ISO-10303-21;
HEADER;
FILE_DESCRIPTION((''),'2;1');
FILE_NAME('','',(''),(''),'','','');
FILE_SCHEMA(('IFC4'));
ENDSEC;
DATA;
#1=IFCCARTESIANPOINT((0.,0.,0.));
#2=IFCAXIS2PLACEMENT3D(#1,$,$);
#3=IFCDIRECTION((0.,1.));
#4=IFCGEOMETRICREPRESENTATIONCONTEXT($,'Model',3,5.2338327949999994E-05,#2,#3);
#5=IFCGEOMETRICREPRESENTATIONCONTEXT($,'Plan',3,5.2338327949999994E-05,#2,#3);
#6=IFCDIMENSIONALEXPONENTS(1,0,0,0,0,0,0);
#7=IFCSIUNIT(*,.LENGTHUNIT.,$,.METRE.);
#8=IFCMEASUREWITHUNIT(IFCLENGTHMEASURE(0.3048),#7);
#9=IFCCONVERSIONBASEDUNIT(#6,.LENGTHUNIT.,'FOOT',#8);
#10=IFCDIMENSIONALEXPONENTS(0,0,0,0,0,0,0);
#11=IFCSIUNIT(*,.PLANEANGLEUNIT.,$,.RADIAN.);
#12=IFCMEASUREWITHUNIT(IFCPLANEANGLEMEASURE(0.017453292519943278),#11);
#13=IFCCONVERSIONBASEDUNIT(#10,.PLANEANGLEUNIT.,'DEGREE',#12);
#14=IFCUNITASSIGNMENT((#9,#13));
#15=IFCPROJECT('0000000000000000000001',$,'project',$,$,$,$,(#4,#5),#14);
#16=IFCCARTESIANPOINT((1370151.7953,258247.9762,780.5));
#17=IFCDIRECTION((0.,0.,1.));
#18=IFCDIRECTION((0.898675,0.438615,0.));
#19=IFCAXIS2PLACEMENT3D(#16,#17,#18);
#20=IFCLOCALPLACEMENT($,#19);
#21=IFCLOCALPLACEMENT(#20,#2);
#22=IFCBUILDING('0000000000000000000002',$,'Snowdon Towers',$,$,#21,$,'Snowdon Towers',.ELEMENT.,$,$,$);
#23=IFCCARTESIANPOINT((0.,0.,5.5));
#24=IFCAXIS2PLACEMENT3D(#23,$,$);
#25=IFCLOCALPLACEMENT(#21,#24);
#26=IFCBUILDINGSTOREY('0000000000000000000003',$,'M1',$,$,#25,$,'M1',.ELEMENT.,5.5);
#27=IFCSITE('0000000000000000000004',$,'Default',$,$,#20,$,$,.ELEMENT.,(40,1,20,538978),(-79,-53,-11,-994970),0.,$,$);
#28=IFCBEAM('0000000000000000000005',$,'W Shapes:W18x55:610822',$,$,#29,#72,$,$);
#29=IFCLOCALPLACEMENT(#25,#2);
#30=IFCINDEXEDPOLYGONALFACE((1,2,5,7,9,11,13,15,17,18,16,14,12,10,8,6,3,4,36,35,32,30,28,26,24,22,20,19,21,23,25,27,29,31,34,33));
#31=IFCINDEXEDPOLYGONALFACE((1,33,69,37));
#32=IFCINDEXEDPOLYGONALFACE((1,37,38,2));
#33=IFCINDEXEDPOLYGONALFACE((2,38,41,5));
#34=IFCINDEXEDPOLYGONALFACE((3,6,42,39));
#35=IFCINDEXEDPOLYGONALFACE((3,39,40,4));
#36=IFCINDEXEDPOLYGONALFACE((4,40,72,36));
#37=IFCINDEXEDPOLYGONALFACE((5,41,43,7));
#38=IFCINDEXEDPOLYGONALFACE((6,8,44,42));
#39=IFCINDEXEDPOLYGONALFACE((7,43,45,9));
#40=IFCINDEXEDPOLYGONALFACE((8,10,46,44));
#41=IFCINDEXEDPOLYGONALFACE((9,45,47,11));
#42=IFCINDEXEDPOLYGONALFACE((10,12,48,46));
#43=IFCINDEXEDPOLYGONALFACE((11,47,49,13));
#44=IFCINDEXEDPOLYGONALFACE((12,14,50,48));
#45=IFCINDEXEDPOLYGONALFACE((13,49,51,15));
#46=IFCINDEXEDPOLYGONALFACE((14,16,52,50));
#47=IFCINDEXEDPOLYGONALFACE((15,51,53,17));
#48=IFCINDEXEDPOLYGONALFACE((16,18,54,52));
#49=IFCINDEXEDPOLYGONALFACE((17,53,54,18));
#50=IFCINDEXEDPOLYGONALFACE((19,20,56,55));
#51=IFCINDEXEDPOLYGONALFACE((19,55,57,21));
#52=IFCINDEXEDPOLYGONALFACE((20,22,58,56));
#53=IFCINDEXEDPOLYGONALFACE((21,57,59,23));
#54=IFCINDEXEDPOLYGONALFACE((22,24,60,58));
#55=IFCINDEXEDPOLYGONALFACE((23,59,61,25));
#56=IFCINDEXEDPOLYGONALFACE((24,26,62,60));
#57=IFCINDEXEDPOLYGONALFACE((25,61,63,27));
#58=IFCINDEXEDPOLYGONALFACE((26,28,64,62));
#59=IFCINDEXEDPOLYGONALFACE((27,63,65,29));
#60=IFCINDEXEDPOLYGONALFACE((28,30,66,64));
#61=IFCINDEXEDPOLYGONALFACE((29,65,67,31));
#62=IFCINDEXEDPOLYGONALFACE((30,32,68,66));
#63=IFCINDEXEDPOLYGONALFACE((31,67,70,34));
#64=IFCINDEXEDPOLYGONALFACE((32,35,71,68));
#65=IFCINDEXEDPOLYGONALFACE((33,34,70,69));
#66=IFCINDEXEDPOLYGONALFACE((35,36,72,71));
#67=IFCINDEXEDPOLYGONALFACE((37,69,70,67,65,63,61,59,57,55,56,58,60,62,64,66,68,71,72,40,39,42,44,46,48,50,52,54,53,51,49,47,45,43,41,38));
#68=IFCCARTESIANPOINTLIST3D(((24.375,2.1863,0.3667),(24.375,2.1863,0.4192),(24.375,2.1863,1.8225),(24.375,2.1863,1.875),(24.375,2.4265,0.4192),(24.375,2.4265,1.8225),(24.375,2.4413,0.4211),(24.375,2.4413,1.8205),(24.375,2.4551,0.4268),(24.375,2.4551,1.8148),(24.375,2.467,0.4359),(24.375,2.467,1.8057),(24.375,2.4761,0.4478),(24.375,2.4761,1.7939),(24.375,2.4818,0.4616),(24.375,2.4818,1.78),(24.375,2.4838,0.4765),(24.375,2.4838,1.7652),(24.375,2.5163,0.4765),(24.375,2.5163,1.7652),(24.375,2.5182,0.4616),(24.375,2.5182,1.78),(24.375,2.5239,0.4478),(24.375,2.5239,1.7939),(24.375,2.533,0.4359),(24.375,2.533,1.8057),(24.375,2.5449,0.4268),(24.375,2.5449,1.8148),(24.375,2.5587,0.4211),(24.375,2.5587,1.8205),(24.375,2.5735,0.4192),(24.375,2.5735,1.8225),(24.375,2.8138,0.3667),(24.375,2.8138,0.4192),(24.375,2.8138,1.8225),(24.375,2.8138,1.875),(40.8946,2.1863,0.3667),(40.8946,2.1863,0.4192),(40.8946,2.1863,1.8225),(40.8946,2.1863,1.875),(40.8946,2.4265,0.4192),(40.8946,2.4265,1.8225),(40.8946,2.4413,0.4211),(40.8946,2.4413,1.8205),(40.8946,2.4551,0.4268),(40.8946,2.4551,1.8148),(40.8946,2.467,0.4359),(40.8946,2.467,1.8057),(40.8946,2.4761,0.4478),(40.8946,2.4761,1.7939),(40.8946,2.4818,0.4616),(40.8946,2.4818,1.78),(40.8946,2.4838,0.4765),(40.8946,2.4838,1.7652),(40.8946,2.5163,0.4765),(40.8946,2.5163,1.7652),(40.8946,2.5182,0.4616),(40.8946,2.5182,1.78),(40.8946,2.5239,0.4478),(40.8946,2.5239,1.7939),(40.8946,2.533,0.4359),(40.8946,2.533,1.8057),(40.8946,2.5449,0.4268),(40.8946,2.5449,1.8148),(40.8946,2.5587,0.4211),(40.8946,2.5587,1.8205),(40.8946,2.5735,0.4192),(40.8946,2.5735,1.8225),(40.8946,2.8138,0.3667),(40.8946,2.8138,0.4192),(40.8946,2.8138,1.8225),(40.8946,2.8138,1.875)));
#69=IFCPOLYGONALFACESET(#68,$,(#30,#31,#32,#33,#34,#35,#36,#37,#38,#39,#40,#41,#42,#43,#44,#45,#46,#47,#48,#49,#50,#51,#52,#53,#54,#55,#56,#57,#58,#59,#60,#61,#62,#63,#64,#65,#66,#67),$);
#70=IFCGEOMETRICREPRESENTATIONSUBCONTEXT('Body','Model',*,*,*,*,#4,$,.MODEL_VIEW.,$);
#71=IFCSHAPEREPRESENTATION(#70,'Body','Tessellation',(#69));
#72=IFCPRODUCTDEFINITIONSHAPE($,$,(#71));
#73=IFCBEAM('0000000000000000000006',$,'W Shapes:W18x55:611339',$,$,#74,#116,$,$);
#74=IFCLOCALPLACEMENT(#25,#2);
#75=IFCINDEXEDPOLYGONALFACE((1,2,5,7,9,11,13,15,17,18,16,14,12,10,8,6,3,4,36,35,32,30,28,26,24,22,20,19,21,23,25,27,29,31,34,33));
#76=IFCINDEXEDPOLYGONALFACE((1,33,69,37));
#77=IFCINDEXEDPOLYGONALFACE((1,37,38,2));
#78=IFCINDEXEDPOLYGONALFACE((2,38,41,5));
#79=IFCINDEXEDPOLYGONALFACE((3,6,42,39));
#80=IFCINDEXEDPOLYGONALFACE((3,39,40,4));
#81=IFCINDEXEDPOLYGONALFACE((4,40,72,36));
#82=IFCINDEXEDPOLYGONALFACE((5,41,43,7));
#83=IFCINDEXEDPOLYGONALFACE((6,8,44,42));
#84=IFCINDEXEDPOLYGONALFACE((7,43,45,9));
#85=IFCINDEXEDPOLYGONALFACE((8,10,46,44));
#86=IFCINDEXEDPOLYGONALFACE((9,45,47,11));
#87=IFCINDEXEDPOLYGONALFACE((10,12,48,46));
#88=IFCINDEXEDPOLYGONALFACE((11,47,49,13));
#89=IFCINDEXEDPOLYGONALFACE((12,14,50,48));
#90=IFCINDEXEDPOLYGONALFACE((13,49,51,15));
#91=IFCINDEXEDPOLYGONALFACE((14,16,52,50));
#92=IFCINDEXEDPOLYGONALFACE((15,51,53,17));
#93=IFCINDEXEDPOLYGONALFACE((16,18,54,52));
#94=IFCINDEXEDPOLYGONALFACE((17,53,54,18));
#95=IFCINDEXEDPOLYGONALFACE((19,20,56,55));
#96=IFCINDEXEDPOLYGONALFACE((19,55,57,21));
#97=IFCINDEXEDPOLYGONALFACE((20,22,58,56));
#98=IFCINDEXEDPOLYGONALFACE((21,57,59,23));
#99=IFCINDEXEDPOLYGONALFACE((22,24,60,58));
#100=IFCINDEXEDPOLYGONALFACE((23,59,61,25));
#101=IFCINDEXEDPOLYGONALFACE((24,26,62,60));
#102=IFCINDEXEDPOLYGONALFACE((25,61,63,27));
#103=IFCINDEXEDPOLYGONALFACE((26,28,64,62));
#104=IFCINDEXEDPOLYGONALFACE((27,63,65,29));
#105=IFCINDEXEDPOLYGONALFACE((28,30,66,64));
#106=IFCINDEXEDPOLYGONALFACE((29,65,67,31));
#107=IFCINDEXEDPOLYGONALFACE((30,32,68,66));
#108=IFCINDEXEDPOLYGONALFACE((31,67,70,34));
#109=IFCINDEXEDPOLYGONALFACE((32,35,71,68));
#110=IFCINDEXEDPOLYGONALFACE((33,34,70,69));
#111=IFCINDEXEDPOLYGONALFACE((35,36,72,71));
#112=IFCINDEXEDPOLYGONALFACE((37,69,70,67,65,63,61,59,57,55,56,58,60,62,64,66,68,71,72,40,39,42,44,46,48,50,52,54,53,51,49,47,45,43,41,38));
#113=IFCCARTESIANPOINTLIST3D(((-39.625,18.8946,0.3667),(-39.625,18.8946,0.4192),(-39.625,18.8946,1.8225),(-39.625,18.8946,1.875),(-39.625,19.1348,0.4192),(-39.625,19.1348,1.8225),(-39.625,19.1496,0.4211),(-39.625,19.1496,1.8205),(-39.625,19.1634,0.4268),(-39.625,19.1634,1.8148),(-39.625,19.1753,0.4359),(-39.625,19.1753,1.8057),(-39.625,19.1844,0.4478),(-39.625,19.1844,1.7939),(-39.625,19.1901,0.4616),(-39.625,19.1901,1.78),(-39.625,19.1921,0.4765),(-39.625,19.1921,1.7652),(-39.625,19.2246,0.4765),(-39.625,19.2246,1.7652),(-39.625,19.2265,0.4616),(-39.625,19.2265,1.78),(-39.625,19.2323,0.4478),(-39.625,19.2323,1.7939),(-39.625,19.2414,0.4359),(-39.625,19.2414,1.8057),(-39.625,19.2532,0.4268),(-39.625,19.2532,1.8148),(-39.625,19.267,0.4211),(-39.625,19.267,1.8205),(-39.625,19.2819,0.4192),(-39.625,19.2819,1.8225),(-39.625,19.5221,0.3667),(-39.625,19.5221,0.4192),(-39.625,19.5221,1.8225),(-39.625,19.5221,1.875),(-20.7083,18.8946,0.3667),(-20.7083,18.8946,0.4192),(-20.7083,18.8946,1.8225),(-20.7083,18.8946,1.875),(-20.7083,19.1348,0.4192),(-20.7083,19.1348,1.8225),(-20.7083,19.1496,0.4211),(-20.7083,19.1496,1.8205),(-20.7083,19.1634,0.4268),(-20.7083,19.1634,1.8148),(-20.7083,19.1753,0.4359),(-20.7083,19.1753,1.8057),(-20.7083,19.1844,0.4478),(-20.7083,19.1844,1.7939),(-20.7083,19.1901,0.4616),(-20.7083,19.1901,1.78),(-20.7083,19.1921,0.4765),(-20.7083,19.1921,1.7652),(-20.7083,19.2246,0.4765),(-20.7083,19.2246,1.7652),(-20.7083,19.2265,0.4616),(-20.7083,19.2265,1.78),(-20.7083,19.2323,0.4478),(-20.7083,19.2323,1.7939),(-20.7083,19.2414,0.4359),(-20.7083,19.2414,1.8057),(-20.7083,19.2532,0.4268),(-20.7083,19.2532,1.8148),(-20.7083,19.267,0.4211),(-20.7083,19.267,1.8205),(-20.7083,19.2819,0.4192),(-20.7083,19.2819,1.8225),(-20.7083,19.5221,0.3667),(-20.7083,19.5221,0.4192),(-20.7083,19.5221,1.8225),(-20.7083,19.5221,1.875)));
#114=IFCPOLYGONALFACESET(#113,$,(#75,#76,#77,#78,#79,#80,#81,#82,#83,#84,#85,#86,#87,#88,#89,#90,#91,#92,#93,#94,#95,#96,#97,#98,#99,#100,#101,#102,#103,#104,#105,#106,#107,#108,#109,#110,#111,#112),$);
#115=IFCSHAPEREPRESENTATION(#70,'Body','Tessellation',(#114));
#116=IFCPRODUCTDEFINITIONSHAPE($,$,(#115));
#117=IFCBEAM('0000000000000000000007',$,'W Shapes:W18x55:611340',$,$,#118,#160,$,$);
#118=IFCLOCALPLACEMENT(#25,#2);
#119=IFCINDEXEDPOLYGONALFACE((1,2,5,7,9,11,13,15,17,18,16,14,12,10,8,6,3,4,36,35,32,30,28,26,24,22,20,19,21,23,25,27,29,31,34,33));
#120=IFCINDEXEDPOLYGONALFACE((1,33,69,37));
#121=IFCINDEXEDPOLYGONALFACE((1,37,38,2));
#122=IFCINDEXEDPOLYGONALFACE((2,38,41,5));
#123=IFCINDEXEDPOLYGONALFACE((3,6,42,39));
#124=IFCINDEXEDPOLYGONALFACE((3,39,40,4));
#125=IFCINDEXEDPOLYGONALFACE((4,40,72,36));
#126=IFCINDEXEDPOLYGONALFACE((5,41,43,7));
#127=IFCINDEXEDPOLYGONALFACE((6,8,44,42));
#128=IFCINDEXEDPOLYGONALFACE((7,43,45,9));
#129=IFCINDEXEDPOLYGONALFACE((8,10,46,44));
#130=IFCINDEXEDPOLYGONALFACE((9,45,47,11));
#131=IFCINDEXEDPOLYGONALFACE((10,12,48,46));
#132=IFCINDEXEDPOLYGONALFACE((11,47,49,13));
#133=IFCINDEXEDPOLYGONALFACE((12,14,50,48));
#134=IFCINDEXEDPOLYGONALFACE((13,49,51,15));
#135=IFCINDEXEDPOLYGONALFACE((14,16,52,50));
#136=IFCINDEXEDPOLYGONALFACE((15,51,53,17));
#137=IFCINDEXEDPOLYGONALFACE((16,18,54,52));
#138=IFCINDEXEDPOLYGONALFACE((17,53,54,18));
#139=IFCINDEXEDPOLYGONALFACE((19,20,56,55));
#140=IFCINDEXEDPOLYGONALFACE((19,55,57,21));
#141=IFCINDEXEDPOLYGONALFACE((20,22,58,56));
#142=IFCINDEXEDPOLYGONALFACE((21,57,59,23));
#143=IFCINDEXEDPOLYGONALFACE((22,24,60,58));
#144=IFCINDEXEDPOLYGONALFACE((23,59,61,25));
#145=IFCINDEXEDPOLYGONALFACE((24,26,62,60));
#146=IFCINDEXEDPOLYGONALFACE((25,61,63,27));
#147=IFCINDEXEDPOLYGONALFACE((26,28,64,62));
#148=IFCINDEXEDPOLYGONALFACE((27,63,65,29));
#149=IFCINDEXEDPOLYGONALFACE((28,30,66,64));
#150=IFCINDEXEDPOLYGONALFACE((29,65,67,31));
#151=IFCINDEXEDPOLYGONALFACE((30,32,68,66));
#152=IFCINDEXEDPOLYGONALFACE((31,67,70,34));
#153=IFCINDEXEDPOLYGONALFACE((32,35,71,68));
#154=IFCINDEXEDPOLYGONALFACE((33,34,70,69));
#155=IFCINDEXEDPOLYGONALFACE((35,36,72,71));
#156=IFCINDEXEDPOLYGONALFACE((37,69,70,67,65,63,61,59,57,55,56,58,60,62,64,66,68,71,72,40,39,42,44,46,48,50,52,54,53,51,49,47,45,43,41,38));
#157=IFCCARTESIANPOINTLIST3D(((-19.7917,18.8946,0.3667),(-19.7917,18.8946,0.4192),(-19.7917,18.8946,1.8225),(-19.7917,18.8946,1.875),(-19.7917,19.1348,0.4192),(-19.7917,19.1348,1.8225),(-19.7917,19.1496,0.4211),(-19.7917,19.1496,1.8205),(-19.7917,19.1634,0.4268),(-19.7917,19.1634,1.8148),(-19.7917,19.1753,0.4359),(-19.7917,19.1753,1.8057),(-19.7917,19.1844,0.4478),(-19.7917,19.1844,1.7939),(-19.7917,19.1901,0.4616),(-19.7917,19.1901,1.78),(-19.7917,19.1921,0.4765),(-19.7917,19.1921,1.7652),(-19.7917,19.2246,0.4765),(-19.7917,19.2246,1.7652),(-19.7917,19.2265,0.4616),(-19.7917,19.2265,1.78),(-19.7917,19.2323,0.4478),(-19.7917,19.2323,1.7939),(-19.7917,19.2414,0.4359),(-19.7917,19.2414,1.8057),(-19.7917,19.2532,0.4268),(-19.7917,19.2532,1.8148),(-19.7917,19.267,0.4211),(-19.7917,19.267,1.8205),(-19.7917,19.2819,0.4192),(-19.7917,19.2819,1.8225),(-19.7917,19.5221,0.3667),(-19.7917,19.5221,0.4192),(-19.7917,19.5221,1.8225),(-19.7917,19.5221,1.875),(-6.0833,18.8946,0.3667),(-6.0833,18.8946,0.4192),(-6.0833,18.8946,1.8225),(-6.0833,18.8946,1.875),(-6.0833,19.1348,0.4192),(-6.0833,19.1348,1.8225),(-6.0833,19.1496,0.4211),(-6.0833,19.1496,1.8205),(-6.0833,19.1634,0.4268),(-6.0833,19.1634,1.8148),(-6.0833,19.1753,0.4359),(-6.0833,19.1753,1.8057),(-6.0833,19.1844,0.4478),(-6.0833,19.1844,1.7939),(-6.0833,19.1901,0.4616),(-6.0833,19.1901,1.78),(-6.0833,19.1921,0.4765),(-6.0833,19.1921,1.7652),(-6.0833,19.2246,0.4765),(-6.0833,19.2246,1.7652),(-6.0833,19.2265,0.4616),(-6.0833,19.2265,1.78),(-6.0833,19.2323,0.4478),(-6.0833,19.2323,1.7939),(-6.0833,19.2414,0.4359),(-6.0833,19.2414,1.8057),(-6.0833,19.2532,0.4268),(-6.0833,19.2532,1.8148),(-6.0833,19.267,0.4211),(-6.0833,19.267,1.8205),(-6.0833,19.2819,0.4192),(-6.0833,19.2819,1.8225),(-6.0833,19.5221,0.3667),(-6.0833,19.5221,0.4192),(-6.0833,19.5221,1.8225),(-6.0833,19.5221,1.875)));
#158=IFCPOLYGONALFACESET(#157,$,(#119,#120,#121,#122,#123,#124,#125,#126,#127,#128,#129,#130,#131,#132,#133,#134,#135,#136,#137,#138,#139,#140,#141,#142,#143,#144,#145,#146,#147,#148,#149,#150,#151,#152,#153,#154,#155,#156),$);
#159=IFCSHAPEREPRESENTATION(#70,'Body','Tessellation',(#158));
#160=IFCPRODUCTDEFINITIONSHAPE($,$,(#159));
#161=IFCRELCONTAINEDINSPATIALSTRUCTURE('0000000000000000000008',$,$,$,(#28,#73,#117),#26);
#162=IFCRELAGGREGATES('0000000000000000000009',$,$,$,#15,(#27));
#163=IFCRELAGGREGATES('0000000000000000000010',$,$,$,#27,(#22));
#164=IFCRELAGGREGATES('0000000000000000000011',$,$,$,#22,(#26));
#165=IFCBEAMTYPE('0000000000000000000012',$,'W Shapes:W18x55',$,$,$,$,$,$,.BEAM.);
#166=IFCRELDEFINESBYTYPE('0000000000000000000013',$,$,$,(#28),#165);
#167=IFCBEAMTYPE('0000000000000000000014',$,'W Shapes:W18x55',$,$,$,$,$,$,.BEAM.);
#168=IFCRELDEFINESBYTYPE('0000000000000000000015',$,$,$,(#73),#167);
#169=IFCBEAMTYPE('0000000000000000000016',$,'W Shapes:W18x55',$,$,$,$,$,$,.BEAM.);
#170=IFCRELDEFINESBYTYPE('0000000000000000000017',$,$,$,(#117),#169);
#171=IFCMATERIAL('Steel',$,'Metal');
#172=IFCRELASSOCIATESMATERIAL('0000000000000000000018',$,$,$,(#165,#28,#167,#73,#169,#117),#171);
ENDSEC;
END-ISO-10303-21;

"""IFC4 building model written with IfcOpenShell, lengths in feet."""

from ifc_helpers import new_model, entity, si_unit, converted_unit, direction, frame, origin, place, context, subcontext, project, spatial, line, arc, indexed_curve, outline, extrude, source, transform, mapped, material, type_object, type_shapes, element, save


model = new_model("IFC4")

# Units and contexts
model_context = context("Model", 3, precision=5.2338327949999994e-05, world=origin(), true_north=direction((0.0, 1.0)))
plan_context = context("Plan", 3, precision=5.2338327949999994e-05, world=origin(), true_north=direction((0.0, 1.0)))
body_context = subcontext(model_context, "Body", "Model", "MODEL_VIEW")
ifc_project = project(units=[converted_unit("LENGTHUNIT", "FOOT", entity("IfcLengthMeasure", 0.3048), si_unit("LENGTHUNIT", "METRE"), dimensions=[1, 0, 0, 0, 0, 0, 0]), converted_unit("PLANEANGLEUNIT", "DEGREE", entity("IfcPlaneAngleMeasure", 0.017453292519943278), si_unit("PLANEANGLEUNIT", "RADIAN"), dimensions=[0, 0, 0, 0, 0, 0, 0])], contexts=[model_context, plan_context])

# Site, building, storey
site_placement = place(None, frame((1370151.7953, 258247.9762, 780.5), z_axis=(0.0, 0.0, 1.0), x_axis=(0.898675, 0.438615, 0.0)))
site = spatial("IfcSite", under=ifc_project, at=site_placement, Name="Default", CompositionType="ELEMENT", RefLatitude=(40, 1, 20, 538978), RefLongitude=(-79, -53, -11, -994970), RefElevation=0.0)
building_placement = place(site_placement, origin())
building = spatial("IfcBuilding", under=site, at=building_placement, Name="Snowdon Towers", LongName="Snowdon Towers", CompositionType="ELEMENT")
storey_placement = place(building_placement, frame((0.0, 0.0, 5.5)))
storey = spatial("IfcBuildingStorey", under=building, at=storey_placement, Name="M1", LongName="M1", CompositionType="ELEMENT", Elevation=5.5)

# Beams
ifc_material_1 = material(Name="Steel", Category="Metal")
beam_type_1 = type_object("IfcBeamType", Name="W Shapes:W18x55", PredefinedType="BEAM", material=ifc_material_1)
shared_shape_1 = source(origin(), body_context, "Body", "SweptSolid", [
    extrude(outline(indexed_curve([(-0.7542, -0.3138), (-0.7017, -0.3138), (-0.7017, -0.0735), (-0.6849, -0.033), (-0.6444, -0.0162), (0.6444, -0.0162), (0.6849, -0.033), (0.7017, -0.0735), (0.7017, -0.3138), (0.7542, -0.3138), (0.7542, 0.3138), (0.7017, 0.3138), (0.7017, 0.0735), (0.6849, 0.033), (0.6444, 0.0163), (-0.6444, 0.0163), (-0.6849, 0.033), (-0.7017, 0.0735), (-0.7017, 0.3137), (-0.7542, 0.3137)], segments=[line(1, 2, 3), arc(3, 4, 5), line(5, 6), arc(6, 7, 8), line(8, 9, 10, 11, 12, 13), arc(13, 14, 15), line(15, 16), arc(16, 17, 18), line(18, 19, 20, 1)], self_intersect=False)), frame((-8.2083, 0.0, 0.0), z_axis=(1.0, 0.0, 0.0), x_axis=(0.0, 0.0, -1.0)), (0.0, 0.0, 1.0), 16.5196),
])
type_shapes(beam_type_1, [shared_shape_1])
beam_1_placement = place(storey_placement, frame((32.5833, 2.5, 1.1208)))
element("IfcBeam", 1, at=beam_1_placement, inside=storey, type_object=beam_type_1, material=ifc_material_1, Name="W Shapes:W18x55:610822", context=body_context, shape_type="MappedRepresentation", body=[
    mapped(shared_shape_1, transform((0.0, 0.0, 0.0), scale=1.0)),
])
beam_type_2 = type_object("IfcBeamType", Name="W Shapes:W18x55", PredefinedType="BEAM", material=ifc_material_1)
shared_shape_2 = source(origin(), body_context, "Body", "SweptSolid", [
    extrude(outline(indexed_curve([(-0.7542, -0.3138), (-0.7017, -0.3138), (-0.7017, -0.0735), (-0.6849, -0.033), (-0.6444, -0.0162), (0.6444, -0.0162), (0.6849, -0.033), (0.7017, -0.0735), (0.7017, -0.3138), (0.7542, -0.3138), (0.7542, 0.3138), (0.7017, 0.3138), (0.7017, 0.0735), (0.6849, 0.033), (0.6444, 0.0163), (-0.6444, 0.0163), (-0.6849, 0.033), (-0.7017, 0.0735), (-0.7017, 0.3137), (-0.7542, 0.3137)], segments=[line(1, 2, 3), arc(3, 4, 5), line(5, 6), arc(6, 7, 8), line(8, 9, 10, 11, 12, 13), arc(13, 14, 15), line(15, 16), arc(16, 17, 18), line(18, 19, 20, 1)], self_intersect=False)), frame((-9.5625, 0.0, 0.0), z_axis=(1.0, 0.0, 0.0), x_axis=(0.0, 0.0, -1.0)), (0.0, 0.0, 1.0), 18.9167),
])
type_shapes(beam_type_2, [shared_shape_2])
beam_2_placement = place(storey_placement, frame((-30.0625, 19.2083, 1.1208)))
element("IfcBeam", 2, at=beam_2_placement, inside=storey, type_object=beam_type_2, material=ifc_material_1, Name="W Shapes:W18x55:611339", context=body_context, shape_type="MappedRepresentation", body=[
    mapped(shared_shape_2, transform((0.0, 0.0, 0.0), scale=1.0)),
])
beam_type_3 = type_object("IfcBeamType", Name="W Shapes:W18x55", PredefinedType="BEAM", material=ifc_material_1)
shared_shape_3 = source(origin(), body_context, "Body", "SweptSolid", [
    extrude(outline(indexed_curve([(-0.7542, -0.3138), (-0.7017, -0.3138), (-0.7017, -0.0735), (-0.6849, -0.033), (-0.6444, -0.0162), (0.6444, -0.0162), (0.6849, -0.033), (0.7017, -0.0735), (0.7017, -0.3138), (0.7542, -0.3138), (0.7542, 0.3138), (0.7017, 0.3138), (0.7017, 0.0735), (0.6849, 0.033), (0.6444, 0.0163), (-0.6444, 0.0163), (-0.6849, 0.033), (-0.7017, 0.0735), (-0.7017, 0.3137), (-0.7542, 0.3137)], segments=[line(1, 2, 3), arc(3, 4, 5), line(5, 6), arc(6, 7, 8), line(8, 9, 10, 11, 12, 13), arc(13, 14, 15), line(15, 16), arc(16, 17, 18), line(18, 19, 20, 1)], self_intersect=False)), frame((-6.625, 0.0, 0.0), z_axis=(1.0, 0.0, 0.0), x_axis=(0.0, 0.0, -1.0)), (0.0, 0.0, 1.0), 13.7083),
])
type_shapes(beam_type_3, [shared_shape_3])
beam_3_placement = place(storey_placement, frame((-13.1667, 19.2083, 1.1208)))
element("IfcBeam", 3, at=beam_3_placement, inside=storey, type_object=beam_type_3, material=ifc_material_1, Name="W Shapes:W18x55:611340", context=body_context, shape_type="MappedRepresentation", body=[
    mapped(shared_shape_3, transform((0.0, 0.0, 0.0), scale=1.0)),
])

save(model, "model.ifc")
